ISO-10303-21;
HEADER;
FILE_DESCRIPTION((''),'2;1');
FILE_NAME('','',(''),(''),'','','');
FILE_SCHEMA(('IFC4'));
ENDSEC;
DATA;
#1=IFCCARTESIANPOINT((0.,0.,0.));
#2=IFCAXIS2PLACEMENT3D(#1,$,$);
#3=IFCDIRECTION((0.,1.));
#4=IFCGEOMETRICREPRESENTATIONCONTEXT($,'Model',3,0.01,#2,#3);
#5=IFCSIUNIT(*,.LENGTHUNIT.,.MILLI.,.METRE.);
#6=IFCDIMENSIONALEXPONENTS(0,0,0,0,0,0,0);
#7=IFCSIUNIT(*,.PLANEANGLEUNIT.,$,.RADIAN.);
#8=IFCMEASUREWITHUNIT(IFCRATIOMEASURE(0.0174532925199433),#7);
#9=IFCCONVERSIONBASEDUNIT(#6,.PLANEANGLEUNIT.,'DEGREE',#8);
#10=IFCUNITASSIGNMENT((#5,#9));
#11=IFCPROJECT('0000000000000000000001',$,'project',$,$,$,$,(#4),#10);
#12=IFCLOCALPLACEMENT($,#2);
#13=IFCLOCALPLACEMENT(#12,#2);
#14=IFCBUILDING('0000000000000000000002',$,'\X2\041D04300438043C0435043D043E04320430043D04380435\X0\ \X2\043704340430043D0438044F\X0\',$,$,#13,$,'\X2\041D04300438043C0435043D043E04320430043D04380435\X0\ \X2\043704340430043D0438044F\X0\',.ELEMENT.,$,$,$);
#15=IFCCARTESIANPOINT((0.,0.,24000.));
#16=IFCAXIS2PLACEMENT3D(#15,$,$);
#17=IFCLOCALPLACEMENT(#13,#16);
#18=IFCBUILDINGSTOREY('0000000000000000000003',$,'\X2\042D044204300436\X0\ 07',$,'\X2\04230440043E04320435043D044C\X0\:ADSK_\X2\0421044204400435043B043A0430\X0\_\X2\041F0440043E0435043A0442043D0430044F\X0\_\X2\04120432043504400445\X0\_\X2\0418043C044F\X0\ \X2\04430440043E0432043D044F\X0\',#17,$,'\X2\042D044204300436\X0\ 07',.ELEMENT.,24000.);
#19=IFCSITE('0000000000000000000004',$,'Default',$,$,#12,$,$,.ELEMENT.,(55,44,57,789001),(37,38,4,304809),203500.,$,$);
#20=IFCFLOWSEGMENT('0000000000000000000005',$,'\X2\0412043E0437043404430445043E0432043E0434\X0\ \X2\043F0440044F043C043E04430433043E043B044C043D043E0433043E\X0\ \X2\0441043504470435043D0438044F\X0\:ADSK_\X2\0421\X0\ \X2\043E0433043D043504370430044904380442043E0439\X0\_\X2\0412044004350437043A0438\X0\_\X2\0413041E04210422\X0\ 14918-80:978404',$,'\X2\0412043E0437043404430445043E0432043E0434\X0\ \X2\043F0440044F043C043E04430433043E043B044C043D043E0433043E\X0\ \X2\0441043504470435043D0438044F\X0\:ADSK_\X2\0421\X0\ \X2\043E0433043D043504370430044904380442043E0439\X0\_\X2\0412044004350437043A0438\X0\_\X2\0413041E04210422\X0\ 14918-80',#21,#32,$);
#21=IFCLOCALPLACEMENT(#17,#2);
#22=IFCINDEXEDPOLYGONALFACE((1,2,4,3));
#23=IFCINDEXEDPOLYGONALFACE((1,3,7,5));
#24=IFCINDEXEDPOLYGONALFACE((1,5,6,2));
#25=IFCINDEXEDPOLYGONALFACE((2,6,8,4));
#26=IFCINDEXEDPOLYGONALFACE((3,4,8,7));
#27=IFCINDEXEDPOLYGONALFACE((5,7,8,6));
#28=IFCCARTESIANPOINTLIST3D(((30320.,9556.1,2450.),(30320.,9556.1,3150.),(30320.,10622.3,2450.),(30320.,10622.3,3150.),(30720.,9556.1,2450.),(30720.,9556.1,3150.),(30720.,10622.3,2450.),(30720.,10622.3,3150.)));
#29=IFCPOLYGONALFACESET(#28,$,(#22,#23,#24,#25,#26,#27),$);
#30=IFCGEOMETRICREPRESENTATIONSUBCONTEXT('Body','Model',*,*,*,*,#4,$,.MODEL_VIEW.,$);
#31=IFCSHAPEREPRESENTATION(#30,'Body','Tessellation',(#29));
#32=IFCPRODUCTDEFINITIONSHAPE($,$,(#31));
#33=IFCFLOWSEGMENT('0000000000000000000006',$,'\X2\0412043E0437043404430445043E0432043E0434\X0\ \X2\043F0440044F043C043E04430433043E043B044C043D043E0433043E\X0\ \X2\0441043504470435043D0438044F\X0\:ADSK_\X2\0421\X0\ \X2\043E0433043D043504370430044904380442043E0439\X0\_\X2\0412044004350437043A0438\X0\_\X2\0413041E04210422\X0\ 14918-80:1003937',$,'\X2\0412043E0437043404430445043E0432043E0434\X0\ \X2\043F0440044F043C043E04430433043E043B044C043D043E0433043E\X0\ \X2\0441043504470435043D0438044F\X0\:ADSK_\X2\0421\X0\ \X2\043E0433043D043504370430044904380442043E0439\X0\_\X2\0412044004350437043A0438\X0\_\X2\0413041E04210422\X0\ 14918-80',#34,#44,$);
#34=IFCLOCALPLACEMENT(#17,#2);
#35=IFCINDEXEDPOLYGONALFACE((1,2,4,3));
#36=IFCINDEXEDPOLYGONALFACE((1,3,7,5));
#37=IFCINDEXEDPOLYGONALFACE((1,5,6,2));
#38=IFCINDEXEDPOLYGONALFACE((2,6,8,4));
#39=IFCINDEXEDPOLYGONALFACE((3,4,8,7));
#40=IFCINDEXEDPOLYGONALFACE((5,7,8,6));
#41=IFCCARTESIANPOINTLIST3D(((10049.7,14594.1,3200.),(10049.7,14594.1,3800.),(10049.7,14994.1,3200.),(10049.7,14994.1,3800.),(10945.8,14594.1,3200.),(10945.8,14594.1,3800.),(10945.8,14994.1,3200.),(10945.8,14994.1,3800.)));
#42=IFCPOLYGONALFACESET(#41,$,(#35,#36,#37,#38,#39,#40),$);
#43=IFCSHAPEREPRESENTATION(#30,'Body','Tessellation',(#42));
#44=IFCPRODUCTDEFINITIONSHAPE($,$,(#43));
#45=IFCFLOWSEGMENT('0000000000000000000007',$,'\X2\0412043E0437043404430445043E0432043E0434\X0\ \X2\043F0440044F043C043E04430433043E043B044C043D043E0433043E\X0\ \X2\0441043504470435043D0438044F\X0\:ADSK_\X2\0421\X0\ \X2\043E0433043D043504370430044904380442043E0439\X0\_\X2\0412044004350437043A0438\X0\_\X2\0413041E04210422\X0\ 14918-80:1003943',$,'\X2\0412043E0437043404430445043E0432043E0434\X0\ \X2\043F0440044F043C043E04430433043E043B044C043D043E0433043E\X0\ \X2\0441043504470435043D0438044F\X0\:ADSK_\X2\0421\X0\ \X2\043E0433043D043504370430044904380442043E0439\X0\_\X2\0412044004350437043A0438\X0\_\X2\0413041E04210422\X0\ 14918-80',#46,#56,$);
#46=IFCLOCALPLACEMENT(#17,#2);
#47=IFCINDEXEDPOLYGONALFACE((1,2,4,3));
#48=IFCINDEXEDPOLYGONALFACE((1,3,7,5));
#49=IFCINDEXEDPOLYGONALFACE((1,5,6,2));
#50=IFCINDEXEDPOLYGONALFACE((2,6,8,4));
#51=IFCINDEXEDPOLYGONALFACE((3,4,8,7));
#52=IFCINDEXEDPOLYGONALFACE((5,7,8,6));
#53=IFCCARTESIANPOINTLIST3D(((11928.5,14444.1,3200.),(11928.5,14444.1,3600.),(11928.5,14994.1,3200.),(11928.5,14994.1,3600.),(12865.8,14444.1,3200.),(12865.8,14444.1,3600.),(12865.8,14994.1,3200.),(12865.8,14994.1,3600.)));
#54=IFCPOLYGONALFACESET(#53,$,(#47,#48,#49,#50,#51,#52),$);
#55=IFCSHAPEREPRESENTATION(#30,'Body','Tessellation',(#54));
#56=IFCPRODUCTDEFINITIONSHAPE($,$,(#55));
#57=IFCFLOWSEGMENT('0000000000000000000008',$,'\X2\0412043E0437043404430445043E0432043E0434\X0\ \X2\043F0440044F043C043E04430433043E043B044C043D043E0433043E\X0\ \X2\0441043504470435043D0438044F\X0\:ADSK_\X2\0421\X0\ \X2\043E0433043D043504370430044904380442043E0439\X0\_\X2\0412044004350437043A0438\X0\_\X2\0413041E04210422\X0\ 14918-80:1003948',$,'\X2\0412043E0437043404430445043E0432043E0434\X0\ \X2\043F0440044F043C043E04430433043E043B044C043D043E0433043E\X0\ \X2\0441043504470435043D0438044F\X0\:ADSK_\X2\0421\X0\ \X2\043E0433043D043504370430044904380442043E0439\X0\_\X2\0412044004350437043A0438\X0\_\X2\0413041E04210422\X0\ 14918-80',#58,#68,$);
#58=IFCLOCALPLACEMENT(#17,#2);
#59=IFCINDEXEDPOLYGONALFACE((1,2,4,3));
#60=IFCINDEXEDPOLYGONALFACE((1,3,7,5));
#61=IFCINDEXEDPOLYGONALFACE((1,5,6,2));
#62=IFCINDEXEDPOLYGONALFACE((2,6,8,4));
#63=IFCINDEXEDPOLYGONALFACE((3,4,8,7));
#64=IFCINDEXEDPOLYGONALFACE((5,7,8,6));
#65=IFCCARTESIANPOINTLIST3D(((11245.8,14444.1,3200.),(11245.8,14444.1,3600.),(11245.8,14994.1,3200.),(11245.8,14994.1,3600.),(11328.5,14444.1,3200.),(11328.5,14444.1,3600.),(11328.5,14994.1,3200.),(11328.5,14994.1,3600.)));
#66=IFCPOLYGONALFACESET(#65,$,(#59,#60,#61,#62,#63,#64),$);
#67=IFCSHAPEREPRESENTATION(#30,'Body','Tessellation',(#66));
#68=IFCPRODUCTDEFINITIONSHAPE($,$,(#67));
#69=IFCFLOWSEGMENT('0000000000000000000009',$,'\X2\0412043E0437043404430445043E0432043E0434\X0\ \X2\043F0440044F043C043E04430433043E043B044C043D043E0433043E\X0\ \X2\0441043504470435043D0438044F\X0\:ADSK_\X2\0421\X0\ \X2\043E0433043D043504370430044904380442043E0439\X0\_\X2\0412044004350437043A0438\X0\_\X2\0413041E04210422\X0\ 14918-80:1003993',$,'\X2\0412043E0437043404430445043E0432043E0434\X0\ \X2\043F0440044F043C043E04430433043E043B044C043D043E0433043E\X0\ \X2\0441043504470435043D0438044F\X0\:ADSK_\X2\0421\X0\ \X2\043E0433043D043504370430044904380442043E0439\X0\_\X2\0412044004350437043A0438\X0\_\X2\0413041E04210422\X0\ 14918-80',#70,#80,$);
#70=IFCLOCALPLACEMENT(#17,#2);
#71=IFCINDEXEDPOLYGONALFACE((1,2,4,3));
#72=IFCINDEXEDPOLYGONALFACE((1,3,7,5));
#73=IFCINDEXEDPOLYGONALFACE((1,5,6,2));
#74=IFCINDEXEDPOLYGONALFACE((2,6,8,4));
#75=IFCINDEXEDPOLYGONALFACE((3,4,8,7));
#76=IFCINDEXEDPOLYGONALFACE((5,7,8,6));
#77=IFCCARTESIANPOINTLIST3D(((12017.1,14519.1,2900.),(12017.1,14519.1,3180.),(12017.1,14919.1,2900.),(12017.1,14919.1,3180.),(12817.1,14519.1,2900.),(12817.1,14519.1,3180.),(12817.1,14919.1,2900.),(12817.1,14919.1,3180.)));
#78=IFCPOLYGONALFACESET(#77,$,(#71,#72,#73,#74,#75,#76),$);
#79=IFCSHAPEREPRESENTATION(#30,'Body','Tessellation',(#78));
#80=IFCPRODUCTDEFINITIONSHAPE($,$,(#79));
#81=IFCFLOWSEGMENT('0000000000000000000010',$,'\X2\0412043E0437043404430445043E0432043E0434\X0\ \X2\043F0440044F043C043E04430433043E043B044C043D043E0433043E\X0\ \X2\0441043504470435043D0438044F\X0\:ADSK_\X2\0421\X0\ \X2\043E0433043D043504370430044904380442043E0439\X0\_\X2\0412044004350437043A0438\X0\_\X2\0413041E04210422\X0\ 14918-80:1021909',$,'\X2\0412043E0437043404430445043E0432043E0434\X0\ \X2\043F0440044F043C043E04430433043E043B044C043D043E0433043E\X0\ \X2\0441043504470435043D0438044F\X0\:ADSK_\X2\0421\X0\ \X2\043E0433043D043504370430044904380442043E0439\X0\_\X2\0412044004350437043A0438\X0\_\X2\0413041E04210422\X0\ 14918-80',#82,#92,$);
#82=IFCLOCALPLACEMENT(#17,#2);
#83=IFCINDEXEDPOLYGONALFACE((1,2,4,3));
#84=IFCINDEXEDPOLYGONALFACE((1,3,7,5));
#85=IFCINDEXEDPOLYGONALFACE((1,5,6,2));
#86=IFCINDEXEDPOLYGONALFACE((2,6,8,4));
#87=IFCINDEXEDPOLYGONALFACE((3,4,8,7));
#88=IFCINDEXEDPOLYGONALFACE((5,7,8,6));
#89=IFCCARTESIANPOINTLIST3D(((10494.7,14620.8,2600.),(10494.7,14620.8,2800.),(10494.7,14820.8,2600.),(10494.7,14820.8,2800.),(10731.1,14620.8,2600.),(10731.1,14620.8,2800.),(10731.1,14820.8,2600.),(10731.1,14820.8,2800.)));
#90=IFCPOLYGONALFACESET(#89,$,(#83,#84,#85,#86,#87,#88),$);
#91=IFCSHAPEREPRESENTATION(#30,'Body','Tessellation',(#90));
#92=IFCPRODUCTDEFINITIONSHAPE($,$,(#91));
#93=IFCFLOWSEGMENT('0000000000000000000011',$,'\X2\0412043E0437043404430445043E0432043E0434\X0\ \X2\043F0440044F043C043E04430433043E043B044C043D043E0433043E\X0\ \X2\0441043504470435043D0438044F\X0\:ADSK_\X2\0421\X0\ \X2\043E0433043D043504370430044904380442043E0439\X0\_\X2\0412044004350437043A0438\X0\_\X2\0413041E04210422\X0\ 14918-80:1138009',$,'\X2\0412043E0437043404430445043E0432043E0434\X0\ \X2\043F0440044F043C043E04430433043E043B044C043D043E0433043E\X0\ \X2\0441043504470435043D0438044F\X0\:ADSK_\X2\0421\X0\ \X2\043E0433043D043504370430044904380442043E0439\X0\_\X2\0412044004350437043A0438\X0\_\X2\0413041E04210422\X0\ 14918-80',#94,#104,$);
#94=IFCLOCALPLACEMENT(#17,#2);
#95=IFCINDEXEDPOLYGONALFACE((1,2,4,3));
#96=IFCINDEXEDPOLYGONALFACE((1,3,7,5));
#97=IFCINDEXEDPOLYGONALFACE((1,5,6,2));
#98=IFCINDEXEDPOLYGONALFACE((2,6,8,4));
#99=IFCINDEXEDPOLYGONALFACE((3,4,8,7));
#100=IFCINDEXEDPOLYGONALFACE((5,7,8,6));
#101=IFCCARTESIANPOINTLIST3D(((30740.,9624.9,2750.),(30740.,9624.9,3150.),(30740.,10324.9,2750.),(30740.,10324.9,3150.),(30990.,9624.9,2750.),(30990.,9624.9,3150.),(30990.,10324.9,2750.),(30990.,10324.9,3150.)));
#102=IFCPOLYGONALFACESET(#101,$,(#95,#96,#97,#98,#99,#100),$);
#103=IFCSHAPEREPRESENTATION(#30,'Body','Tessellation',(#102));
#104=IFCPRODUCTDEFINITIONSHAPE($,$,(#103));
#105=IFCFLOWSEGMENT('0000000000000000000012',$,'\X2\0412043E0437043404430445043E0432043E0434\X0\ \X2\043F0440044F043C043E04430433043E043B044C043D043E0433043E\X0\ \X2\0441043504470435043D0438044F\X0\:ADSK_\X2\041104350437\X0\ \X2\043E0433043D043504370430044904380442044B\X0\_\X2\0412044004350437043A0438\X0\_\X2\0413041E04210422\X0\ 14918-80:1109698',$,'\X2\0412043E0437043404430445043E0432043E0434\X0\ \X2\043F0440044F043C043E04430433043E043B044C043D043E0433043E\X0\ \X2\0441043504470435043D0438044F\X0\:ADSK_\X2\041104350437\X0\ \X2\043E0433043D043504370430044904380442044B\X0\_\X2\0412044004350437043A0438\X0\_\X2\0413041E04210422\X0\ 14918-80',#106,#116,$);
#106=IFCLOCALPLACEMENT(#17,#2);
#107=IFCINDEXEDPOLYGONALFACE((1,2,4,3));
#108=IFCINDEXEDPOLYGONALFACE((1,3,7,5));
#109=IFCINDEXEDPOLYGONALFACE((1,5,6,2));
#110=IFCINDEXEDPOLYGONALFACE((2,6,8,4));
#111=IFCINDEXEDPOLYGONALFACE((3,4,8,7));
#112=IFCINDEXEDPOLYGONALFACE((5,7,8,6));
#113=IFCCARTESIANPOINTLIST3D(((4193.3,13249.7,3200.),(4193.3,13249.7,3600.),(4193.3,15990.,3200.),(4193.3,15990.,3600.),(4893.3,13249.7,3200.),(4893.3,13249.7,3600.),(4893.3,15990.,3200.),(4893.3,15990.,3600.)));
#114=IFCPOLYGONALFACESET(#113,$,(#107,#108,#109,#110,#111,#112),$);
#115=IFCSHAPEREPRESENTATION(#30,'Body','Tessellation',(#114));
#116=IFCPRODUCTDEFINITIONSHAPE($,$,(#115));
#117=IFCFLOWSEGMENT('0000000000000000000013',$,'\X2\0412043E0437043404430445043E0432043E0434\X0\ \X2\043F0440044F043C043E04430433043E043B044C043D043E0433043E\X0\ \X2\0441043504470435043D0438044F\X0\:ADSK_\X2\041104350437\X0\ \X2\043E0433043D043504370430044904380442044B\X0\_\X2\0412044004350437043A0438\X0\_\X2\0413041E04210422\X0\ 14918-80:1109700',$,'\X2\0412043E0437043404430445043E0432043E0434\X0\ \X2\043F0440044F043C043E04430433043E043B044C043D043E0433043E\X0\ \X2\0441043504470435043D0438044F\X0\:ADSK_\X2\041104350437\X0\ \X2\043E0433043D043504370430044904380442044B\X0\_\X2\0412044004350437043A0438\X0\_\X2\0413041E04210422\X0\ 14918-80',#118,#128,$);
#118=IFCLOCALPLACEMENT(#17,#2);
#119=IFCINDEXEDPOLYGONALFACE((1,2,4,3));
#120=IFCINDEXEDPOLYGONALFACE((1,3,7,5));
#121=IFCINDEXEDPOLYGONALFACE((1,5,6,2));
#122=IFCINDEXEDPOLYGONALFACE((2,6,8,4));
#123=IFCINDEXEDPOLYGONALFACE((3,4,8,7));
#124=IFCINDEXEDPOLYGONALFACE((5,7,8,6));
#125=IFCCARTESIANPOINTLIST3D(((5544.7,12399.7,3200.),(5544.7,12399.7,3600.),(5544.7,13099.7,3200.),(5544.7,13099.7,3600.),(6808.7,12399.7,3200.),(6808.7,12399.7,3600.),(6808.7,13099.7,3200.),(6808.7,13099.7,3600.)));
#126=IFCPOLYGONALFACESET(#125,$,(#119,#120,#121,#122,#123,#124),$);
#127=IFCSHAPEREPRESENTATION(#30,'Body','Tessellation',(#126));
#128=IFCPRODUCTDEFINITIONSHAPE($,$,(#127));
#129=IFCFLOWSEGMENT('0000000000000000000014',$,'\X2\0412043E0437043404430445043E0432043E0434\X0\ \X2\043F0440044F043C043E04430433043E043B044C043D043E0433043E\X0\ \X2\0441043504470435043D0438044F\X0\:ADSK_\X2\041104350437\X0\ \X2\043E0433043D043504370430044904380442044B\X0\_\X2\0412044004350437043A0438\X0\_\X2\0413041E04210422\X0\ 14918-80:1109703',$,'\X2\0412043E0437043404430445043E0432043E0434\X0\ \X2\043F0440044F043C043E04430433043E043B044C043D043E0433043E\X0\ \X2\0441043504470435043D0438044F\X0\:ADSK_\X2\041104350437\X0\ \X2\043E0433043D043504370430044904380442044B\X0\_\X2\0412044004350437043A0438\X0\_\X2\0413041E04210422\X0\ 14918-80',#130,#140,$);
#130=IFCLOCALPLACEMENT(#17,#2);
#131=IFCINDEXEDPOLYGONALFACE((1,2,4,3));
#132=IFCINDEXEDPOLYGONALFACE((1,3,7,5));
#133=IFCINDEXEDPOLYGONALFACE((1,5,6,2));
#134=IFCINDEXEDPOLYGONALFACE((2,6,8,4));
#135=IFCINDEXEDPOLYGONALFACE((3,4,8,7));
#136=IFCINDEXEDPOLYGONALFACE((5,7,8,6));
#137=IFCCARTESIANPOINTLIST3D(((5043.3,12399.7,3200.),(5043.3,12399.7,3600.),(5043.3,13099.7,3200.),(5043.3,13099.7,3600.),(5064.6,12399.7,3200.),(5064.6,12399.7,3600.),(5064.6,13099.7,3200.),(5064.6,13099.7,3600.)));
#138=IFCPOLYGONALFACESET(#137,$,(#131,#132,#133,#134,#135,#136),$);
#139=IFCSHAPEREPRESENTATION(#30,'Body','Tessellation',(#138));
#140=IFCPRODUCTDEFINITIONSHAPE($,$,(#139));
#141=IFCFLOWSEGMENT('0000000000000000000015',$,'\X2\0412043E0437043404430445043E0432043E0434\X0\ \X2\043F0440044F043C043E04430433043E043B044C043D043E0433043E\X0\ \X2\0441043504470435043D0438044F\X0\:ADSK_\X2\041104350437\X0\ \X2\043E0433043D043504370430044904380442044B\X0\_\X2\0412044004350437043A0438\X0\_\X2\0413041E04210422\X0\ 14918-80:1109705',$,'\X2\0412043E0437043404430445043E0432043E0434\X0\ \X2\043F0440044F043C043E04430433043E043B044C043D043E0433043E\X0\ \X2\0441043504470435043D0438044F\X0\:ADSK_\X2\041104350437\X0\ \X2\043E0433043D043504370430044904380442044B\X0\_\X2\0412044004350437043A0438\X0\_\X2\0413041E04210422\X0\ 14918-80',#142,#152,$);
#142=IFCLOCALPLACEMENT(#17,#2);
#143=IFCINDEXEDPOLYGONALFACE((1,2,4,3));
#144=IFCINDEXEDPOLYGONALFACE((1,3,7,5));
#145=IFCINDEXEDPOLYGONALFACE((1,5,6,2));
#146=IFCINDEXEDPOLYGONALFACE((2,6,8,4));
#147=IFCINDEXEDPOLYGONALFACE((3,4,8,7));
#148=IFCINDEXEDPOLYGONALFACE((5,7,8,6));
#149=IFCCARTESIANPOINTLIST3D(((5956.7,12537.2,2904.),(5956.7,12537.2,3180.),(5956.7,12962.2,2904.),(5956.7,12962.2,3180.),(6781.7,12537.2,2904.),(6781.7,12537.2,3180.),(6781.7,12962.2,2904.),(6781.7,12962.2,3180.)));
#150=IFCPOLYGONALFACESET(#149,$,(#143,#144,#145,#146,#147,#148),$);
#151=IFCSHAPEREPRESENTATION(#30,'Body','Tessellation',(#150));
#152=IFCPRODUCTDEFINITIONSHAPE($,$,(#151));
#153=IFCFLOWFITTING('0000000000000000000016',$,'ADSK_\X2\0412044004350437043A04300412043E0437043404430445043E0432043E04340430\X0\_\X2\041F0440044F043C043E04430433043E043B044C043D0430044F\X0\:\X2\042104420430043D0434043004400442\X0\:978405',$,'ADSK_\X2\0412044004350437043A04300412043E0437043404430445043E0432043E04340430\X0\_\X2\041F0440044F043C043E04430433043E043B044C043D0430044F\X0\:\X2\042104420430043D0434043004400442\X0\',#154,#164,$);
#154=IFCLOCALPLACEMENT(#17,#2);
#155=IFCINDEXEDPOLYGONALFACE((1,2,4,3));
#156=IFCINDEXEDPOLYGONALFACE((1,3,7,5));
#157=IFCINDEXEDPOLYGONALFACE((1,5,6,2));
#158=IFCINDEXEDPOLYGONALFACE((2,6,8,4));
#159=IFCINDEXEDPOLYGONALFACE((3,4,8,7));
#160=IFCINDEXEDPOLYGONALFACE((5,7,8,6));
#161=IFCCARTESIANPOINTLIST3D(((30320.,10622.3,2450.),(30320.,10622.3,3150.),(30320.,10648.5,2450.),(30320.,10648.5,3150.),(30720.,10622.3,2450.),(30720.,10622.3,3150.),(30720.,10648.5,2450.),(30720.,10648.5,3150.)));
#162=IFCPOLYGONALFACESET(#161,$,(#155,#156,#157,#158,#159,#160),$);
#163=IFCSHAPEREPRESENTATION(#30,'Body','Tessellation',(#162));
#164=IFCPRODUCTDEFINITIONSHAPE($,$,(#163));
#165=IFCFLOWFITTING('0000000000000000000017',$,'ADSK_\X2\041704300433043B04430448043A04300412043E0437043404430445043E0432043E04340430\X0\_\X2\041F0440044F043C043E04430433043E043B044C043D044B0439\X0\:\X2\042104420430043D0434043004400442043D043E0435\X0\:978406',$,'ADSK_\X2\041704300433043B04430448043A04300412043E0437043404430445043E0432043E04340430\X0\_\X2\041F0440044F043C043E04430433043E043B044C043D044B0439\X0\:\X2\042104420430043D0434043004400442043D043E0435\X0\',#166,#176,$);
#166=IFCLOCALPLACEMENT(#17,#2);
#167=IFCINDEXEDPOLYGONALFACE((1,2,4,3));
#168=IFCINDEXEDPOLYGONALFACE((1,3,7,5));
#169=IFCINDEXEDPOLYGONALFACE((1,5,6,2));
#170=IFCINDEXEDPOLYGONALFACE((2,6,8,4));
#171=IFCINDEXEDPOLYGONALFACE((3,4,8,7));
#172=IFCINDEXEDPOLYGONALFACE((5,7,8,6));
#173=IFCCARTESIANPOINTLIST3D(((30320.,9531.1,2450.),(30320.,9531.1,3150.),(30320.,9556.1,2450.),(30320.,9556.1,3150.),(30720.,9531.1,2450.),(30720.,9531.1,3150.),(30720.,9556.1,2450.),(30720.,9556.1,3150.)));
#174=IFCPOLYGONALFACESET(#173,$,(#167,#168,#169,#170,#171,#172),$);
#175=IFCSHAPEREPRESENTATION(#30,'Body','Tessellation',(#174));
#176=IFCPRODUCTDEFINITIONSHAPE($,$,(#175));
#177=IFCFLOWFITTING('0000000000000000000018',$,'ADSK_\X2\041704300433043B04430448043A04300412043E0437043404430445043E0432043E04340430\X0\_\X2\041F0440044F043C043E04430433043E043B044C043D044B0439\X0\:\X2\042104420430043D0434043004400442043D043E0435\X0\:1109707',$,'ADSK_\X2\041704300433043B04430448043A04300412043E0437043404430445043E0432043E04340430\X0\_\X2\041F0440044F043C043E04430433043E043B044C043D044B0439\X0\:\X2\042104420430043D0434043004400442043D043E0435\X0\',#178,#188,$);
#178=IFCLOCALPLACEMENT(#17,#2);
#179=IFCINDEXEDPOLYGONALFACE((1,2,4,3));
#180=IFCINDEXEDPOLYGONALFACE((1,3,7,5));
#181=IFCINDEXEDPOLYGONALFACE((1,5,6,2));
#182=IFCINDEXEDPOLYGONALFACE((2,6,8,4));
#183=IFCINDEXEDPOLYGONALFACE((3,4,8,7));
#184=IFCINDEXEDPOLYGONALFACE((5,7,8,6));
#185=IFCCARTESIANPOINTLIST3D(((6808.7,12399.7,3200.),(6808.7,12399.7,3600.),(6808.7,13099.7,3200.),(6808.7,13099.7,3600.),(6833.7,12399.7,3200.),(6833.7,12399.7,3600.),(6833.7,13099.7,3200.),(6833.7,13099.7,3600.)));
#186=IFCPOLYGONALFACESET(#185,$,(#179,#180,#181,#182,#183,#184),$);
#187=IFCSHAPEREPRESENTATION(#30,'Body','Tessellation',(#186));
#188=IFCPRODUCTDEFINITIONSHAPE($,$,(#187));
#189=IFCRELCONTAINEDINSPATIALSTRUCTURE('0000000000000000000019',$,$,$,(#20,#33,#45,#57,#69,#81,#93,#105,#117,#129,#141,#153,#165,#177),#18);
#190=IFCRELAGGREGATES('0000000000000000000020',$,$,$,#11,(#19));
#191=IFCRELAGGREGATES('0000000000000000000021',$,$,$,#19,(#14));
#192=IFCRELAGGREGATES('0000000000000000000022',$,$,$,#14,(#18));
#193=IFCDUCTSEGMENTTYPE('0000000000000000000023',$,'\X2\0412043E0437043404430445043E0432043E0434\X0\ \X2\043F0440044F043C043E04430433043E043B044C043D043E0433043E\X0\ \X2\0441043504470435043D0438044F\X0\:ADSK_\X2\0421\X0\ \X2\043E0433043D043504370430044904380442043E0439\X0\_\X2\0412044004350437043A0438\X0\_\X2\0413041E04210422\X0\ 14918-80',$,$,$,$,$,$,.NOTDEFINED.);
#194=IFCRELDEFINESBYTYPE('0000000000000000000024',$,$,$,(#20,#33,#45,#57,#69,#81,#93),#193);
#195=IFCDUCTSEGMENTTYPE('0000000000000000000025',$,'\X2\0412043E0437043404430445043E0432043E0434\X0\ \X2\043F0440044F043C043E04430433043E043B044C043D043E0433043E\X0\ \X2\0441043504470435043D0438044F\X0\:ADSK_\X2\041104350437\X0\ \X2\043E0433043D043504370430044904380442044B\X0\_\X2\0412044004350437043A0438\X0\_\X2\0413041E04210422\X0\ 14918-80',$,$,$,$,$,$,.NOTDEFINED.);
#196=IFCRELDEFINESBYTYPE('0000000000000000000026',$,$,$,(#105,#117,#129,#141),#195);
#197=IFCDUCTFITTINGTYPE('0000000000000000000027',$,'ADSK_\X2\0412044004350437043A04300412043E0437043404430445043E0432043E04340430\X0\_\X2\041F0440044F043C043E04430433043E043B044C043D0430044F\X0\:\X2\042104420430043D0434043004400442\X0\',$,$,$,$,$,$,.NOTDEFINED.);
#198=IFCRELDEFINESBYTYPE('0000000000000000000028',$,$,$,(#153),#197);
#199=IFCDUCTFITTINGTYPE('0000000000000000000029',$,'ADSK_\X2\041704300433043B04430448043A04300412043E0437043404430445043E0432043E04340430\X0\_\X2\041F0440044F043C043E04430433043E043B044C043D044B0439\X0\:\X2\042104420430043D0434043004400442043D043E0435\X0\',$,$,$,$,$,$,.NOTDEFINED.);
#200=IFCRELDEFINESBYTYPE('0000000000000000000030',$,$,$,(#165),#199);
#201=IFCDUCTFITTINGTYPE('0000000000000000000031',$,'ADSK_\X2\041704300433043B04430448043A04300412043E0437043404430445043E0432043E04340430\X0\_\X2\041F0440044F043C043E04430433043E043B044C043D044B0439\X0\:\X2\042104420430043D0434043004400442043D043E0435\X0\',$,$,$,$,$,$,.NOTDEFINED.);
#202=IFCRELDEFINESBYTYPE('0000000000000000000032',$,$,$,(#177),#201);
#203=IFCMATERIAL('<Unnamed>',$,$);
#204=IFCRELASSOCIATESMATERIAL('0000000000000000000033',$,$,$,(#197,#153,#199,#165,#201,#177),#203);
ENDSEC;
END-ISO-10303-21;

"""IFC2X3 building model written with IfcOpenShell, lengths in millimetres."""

from ifc_helpers import new_model, entity, si_unit, converted_unit, direction, frame, origin, origin_2d_with_axis, place, context, subcontext, project, spatial, rectangle, extrude, source, transform, mapped, material, type_object, type_shapes, element, save


model = new_model("IFC2X3")

# Units and contexts
model_context = context("Model", 3, precision=0.01, world=origin(), true_north=direction((0.0, 1.0)))
body_context = subcontext(model_context, "Body", "Model", "MODEL_VIEW")
ifc_project = project(units=[si_unit("LENGTHUNIT", "METRE", prefix="MILLI"), converted_unit("PLANEANGLEUNIT", "DEGREE", entity("IfcRatioMeasure", 0.0174532925199433), si_unit("PLANEANGLEUNIT", "RADIAN"), dimensions=[0, 0, 0, 0, 0, 0, 0])], contexts=[model_context])

# Site, building, storey
site_placement = place(None, origin())
site = spatial("IfcSite", under=ifc_project, at=site_placement, Name="Default", CompositionType="ELEMENT", RefLatitude=(55, 44, 57, 789001), RefLongitude=(37, 38, 4, 304809), RefElevation=203500.0)
building_placement = place(site_placement, origin())
building = spatial("IfcBuilding", under=site, at=building_placement, Name="Наименование здания", LongName="Наименование здания", CompositionType="ELEMENT")
storey_placement = place(building_placement, frame((0.0, 0.0, 24000.0)))
storey = spatial("IfcBuildingStorey", under=building, at=storey_placement, Name="Этаж 07", ObjectType="Уровень:ADSK_Стрелка_Проектная_Вверх_Имя уровня", LongName="Этаж 07", CompositionType="ELEMENT", Elevation=24000.0)

# Flow segments
duct_segment_type_1 = type_object("IfcDuctSegmentType", Name="Воздуховод прямоугольного сечения:ADSK_С огнезащитой_Врезки_ГОСТ 14918-80", PredefinedType="NOTDEFINED")
flow_segment_1_placement = place(storey_placement, frame((30320.0, 9556.1, 2450.0)))
element("IfcFlowSegment", 1, at=flow_segment_1_placement, inside=storey, type_object=duct_segment_type_1, Name="Воздуховод прямоугольного сечения:ADSK_С огнезащитой_Врезки_ГОСТ 14918-80:978404", ObjectType="Воздуховод прямоугольного сечения:ADSK_С огнезащитой_Врезки_ГОСТ 14918-80", context=body_context, shape_type="SweptSolid", body=[
    extrude(rectangle(XDim=1066.2, YDim=400.0, at=origin_2d_with_axis()), frame((200.0, 533.1, 0.0), z_axis=(0.0, 0.0, 1.0), x_axis=(0.0, -1.0, 0.0)), (0.0, 0.0, 1.0), 700.0),
])
flow_segment_2_placement = place(storey_placement, frame((10049.7, 14594.1, 3200.0)))
element("IfcFlowSegment", 2, at=flow_segment_2_placement, inside=storey, type_object=duct_segment_type_1, Name="Воздуховод прямоугольного сечения:ADSK_С огнезащитой_Врезки_ГОСТ 14918-80:1003937", ObjectType="Воздуховод прямоугольного сечения:ADSK_С огнезащитой_Врезки_ГОСТ 14918-80", context=body_context, shape_type="SweptSolid", body=[
    extrude(rectangle(XDim=896.0, YDim=400.0, at=origin_2d_with_axis()), frame((448.0, 200.0, 0.0), z_axis=(0.0, 0.0, 1.0), x_axis=(-1.0, 0.0, 0.0)), (0.0, 0.0, 1.0), 600.0),
])
flow_segment_3_placement = place(storey_placement, frame((11928.5, 14444.1, 3200.0)))
element("IfcFlowSegment", 3, at=flow_segment_3_placement, inside=storey, type_object=duct_segment_type_1, Name="Воздуховод прямоугольного сечения:ADSK_С огнезащитой_Врезки_ГОСТ 14918-80:1003943", ObjectType="Воздуховод прямоугольного сечения:ADSK_С огнезащитой_Врезки_ГОСТ 14918-80", context=body_context, shape_type="SweptSolid", body=[
    extrude(rectangle(XDim=937.3, YDim=550.0, at=origin_2d_with_axis()), frame((468.6, 275.0, 0.0)), (0.0, 0.0, 1.0), 400.0),
])
flow_segment_4_placement = place(storey_placement, frame((11245.8, 14444.1, 3200.0)))
element("IfcFlowSegment", 4, at=flow_segment_4_placement, inside=storey, type_object=duct_segment_type_1, Name="Воздуховод прямоугольного сечения:ADSK_С огнезащитой_Врезки_ГОСТ 14918-80:1003948", ObjectType="Воздуховод прямоугольного сечения:ADSK_С огнезащитой_Врезки_ГОСТ 14918-80", context=body_context, shape_type="SweptSolid", body=[
    extrude(rectangle(XDim=82.7, YDim=550.0, at=origin_2d_with_axis()), frame((41.4, 275.0, 0.0)), (0.0, 0.0, 1.0), 400.0),
])
flow_segment_5_placement = place(storey_placement, frame((12017.1, 14519.1, 2900.0)))
element("IfcFlowSegment", 5, at=flow_segment_5_placement, inside=storey, type_object=duct_segment_type_1, Name="Воздуховод прямоугольного сечения:ADSK_С огнезащитой_Врезки_ГОСТ 14918-80:1003993", ObjectType="Воздуховод прямоугольного сечения:ADSK_С огнезащитой_Врезки_ГОСТ 14918-80", context=body_context, shape_type="SweptSolid", body=[
    extrude(rectangle(XDim=800.0, YDim=400.0, at=origin_2d_with_axis()), frame((400.0, 200.0, 0.0)), (0.0, 0.0, 1.0), 280.0),
])
flow_segment_6_placement = place(storey_placement, frame((10494.7, 14620.8, 2600.0)))
element("IfcFlowSegment", 6, at=flow_segment_6_placement, inside=storey, type_object=duct_segment_type_1, Name="Воздуховод прямоугольного сечения:ADSK_С огнезащитой_Врезки_ГОСТ 14918-80:1021909", ObjectType="Воздуховод прямоугольного сечения:ADSK_С огнезащитой_Врезки_ГОСТ 14918-80", context=body_context, shape_type="SweptSolid", body=[
    extrude(rectangle(XDim=236.4, YDim=200.0, at=origin_2d_with_axis()), frame((118.2, 100.0, 0.0), z_axis=(0.0, 0.0, 1.0), x_axis=(-1.0, 0.0, 0.0)), (0.0, 0.0, 1.0), 200.0),
])
flow_segment_7_placement = place(storey_placement, frame((30740.0, 9624.9, 2750.0)))
element("IfcFlowSegment", 7, at=flow_segment_7_placement, inside=storey, type_object=duct_segment_type_1, Name="Воздуховод прямоугольного сечения:ADSK_С огнезащитой_Врезки_ГОСТ 14918-80:1138009", ObjectType="Воздуховод прямоугольного сечения:ADSK_С огнезащитой_Врезки_ГОСТ 14918-80", context=body_context, shape_type="SweptSolid", body=[
    extrude(rectangle(XDim=250.0, YDim=700.0, at=origin_2d_with_axis()), frame((125.0, 350.0, 0.0), z_axis=(0.0, 0.0, 1.0), x_axis=(-1.0, 0.0, 0.0)), (0.0, 0.0, 1.0), 400.0),
])
duct_segment_type_2 = type_object("IfcDuctSegmentType", Name="Воздуховод прямоугольного сечения:ADSK_Без огнезащиты_Врезки_ГОСТ 14918-80", PredefinedType="NOTDEFINED")
flow_segment_8_placement = place(storey_placement, frame((4193.3, 13249.7, 3200.0)))
element("IfcFlowSegment", 8, at=flow_segment_8_placement, inside=storey, type_object=duct_segment_type_2, Name="Воздуховод прямоугольного сечения:ADSK_Без огнезащиты_Врезки_ГОСТ 14918-80:1109698", ObjectType="Воздуховод прямоугольного сечения:ADSK_Без огнезащиты_Врезки_ГОСТ 14918-80", context=body_context, shape_type="SweptSolid", body=[
    extrude(rectangle(XDim=2740.3, YDim=700.0, at=origin_2d_with_axis()), frame((350.0, 1370.2, 0.0), z_axis=(0.0, 0.0, 1.0), x_axis=(0.0, 1.0, 0.0)), (0.0, 0.0, 1.0), 400.0),
])
flow_segment_9_placement = place(storey_placement, frame((5544.6, 12399.7, 3200.0)))
element("IfcFlowSegment", 9, at=flow_segment_9_placement, inside=storey, type_object=duct_segment_type_2, Name="Воздуховод прямоугольного сечения:ADSK_Без огнезащиты_Врезки_ГОСТ 14918-80:1109700", ObjectType="Воздуховод прямоугольного сечения:ADSK_Без огнезащиты_Врезки_ГОСТ 14918-80", context=body_context, shape_type="SweptSolid", body=[
    extrude(rectangle(XDim=1264.1, YDim=700.0, at=origin_2d_with_axis()), frame((632.0, 350.0, 0.0)), (0.0, 0.0, 1.0), 400.0),
])
flow_segment_10_placement = place(storey_placement, frame((5043.3, 12399.7, 3200.0)))
element("IfcFlowSegment", 10, at=flow_segment_10_placement, inside=storey, type_object=duct_segment_type_2, Name="Воздуховод прямоугольного сечения:ADSK_Без огнезащиты_Врезки_ГОСТ 14918-80:1109703", ObjectType="Воздуховод прямоугольного сечения:ADSK_Без огнезащиты_Врезки_ГОСТ 14918-80", context=body_context, shape_type="SweptSolid", body=[
    extrude(rectangle(XDim=21.3, YDim=700.0, at=origin_2d_with_axis()), frame((10.7, 350.0, 0.0)), (0.0, 0.0, 1.0), 400.0),
])
flow_segment_11_placement = place(storey_placement, frame((5956.7, 12537.2, 2904.0)))
element("IfcFlowSegment", 11, at=flow_segment_11_placement, inside=storey, type_object=duct_segment_type_2, Name="Воздуховод прямоугольного сечения:ADSK_Без огнезащиты_Врезки_ГОСТ 14918-80:1109705", ObjectType="Воздуховод прямоугольного сечения:ADSK_Без огнезащиты_Врезки_ГОСТ 14918-80", context=body_context, shape_type="SweptSolid", body=[
    extrude(rectangle(XDim=825.0, YDim=425.0, at=origin_2d_with_axis()), frame((412.5, 212.5, 0.0), z_axis=(0.0, 0.0, 1.0), x_axis=(-1.0, 0.0, 0.0)), (0.0, 0.0, 1.0), 276.0),
])

# Flow fittings
ifc_material_1 = material(Name="<Unnamed>")
duct_fitting_type_1 = type_object("IfcDuctFittingType", Name="ADSK_ВрезкаВоздуховода_Прямоугольная:Стандарт", PredefinedType="NOTDEFINED", material=ifc_material_1)
shared_shape_1 = source(origin(), body_context, "Body", "SweptSolid", [
    extrude(rectangle(XDim=26.1, YDim=700.0, at=origin_2d_with_axis()), frame((6.9, 0.0, -200.0)), (0.0, 0.0, 1.0), 400.0),
])
type_shapes(duct_fitting_type_1, [shared_shape_1])
flow_fitting_1_placement = place(storey_placement, frame((30520.0, 10642.3, 2800.0), z_axis=(-1.0, 0.0, 0.0), x_axis=(0.0, -1.0, 0.0)))
element("IfcFlowFitting", 12, at=flow_fitting_1_placement, inside=storey, type_object=duct_fitting_type_1, material=ifc_material_1, Name="ADSK_ВрезкаВоздуховода_Прямоугольная:Стандарт:978405", ObjectType="ADSK_ВрезкаВоздуховода_Прямоугольная:Стандарт", context=body_context, shape_type="MappedRepresentation", body=[
    mapped(shared_shape_1, transform((0.0, 0.0, 0.0), scale=1.0)),
])
duct_fitting_type_2 = type_object("IfcDuctFittingType", Name="ADSK_ЗаглушкаВоздуховода_Прямоугольный:Стандартное", PredefinedType="NOTDEFINED", material=ifc_material_1)
shared_shape_2 = source(origin(), body_context, "Body", "SweptSolid", [
    extrude(rectangle(XDim=25.0, YDim=400.0, at=origin_2d_with_axis()), frame((12.5, 0.0, -350.0)), (0.0, 0.0, 1.0), 700.0),
])
type_shapes(duct_fitting_type_2, [shared_shape_2])
flow_fitting_2_placement = place(storey_placement, frame((30520.0, 9556.1, 2800.0), z_axis=(0.0, 0.0, 1.0), x_axis=(0.0, -1.0, 0.0)))
element("IfcFlowFitting", 13, at=flow_fitting_2_placement, inside=storey, type_object=duct_fitting_type_2, material=ifc_material_1, Name="ADSK_ЗаглушкаВоздуховода_Прямоугольный:Стандартное:978406", ObjectType="ADSK_ЗаглушкаВоздуховода_Прямоугольный:Стандартное", context=body_context, shape_type="MappedRepresentation", body=[
    mapped(shared_shape_2, transform((0.0, 0.0, 0.0), scale=1.0)),
])
duct_fitting_type_3 = type_object("IfcDuctFittingType", Name="ADSK_ЗаглушкаВоздуховода_Прямоугольный:Стандартное", PredefinedType="NOTDEFINED", material=ifc_material_1)
shared_shape_3 = source(origin(), body_context, "Body", "SweptSolid", [
    extrude(rectangle(XDim=25.0, YDim=700.0, at=origin_2d_with_axis()), frame((12.5, 0.0, -200.0)), (0.0, 0.0, 1.0), 400.0),
])
type_shapes(duct_fitting_type_3, [shared_shape_3])
flow_fitting_3_placement = place(storey_placement, frame((6808.7, 12749.7, 3400.0)))
element("IfcFlowFitting", 14, at=flow_fitting_3_placement, inside=storey, type_object=duct_fitting_type_3, material=ifc_material_1, Name="ADSK_ЗаглушкаВоздуховода_Прямоугольный:Стандартное:1109707", ObjectType="ADSK_ЗаглушкаВоздуховода_Прямоугольный:Стандартное", context=body_context, shape_type="MappedRepresentation", body=[
    mapped(shared_shape_3, transform((0.0, 0.0, 0.0), scale=1.0)),
])

save(model, "model.ifc")
